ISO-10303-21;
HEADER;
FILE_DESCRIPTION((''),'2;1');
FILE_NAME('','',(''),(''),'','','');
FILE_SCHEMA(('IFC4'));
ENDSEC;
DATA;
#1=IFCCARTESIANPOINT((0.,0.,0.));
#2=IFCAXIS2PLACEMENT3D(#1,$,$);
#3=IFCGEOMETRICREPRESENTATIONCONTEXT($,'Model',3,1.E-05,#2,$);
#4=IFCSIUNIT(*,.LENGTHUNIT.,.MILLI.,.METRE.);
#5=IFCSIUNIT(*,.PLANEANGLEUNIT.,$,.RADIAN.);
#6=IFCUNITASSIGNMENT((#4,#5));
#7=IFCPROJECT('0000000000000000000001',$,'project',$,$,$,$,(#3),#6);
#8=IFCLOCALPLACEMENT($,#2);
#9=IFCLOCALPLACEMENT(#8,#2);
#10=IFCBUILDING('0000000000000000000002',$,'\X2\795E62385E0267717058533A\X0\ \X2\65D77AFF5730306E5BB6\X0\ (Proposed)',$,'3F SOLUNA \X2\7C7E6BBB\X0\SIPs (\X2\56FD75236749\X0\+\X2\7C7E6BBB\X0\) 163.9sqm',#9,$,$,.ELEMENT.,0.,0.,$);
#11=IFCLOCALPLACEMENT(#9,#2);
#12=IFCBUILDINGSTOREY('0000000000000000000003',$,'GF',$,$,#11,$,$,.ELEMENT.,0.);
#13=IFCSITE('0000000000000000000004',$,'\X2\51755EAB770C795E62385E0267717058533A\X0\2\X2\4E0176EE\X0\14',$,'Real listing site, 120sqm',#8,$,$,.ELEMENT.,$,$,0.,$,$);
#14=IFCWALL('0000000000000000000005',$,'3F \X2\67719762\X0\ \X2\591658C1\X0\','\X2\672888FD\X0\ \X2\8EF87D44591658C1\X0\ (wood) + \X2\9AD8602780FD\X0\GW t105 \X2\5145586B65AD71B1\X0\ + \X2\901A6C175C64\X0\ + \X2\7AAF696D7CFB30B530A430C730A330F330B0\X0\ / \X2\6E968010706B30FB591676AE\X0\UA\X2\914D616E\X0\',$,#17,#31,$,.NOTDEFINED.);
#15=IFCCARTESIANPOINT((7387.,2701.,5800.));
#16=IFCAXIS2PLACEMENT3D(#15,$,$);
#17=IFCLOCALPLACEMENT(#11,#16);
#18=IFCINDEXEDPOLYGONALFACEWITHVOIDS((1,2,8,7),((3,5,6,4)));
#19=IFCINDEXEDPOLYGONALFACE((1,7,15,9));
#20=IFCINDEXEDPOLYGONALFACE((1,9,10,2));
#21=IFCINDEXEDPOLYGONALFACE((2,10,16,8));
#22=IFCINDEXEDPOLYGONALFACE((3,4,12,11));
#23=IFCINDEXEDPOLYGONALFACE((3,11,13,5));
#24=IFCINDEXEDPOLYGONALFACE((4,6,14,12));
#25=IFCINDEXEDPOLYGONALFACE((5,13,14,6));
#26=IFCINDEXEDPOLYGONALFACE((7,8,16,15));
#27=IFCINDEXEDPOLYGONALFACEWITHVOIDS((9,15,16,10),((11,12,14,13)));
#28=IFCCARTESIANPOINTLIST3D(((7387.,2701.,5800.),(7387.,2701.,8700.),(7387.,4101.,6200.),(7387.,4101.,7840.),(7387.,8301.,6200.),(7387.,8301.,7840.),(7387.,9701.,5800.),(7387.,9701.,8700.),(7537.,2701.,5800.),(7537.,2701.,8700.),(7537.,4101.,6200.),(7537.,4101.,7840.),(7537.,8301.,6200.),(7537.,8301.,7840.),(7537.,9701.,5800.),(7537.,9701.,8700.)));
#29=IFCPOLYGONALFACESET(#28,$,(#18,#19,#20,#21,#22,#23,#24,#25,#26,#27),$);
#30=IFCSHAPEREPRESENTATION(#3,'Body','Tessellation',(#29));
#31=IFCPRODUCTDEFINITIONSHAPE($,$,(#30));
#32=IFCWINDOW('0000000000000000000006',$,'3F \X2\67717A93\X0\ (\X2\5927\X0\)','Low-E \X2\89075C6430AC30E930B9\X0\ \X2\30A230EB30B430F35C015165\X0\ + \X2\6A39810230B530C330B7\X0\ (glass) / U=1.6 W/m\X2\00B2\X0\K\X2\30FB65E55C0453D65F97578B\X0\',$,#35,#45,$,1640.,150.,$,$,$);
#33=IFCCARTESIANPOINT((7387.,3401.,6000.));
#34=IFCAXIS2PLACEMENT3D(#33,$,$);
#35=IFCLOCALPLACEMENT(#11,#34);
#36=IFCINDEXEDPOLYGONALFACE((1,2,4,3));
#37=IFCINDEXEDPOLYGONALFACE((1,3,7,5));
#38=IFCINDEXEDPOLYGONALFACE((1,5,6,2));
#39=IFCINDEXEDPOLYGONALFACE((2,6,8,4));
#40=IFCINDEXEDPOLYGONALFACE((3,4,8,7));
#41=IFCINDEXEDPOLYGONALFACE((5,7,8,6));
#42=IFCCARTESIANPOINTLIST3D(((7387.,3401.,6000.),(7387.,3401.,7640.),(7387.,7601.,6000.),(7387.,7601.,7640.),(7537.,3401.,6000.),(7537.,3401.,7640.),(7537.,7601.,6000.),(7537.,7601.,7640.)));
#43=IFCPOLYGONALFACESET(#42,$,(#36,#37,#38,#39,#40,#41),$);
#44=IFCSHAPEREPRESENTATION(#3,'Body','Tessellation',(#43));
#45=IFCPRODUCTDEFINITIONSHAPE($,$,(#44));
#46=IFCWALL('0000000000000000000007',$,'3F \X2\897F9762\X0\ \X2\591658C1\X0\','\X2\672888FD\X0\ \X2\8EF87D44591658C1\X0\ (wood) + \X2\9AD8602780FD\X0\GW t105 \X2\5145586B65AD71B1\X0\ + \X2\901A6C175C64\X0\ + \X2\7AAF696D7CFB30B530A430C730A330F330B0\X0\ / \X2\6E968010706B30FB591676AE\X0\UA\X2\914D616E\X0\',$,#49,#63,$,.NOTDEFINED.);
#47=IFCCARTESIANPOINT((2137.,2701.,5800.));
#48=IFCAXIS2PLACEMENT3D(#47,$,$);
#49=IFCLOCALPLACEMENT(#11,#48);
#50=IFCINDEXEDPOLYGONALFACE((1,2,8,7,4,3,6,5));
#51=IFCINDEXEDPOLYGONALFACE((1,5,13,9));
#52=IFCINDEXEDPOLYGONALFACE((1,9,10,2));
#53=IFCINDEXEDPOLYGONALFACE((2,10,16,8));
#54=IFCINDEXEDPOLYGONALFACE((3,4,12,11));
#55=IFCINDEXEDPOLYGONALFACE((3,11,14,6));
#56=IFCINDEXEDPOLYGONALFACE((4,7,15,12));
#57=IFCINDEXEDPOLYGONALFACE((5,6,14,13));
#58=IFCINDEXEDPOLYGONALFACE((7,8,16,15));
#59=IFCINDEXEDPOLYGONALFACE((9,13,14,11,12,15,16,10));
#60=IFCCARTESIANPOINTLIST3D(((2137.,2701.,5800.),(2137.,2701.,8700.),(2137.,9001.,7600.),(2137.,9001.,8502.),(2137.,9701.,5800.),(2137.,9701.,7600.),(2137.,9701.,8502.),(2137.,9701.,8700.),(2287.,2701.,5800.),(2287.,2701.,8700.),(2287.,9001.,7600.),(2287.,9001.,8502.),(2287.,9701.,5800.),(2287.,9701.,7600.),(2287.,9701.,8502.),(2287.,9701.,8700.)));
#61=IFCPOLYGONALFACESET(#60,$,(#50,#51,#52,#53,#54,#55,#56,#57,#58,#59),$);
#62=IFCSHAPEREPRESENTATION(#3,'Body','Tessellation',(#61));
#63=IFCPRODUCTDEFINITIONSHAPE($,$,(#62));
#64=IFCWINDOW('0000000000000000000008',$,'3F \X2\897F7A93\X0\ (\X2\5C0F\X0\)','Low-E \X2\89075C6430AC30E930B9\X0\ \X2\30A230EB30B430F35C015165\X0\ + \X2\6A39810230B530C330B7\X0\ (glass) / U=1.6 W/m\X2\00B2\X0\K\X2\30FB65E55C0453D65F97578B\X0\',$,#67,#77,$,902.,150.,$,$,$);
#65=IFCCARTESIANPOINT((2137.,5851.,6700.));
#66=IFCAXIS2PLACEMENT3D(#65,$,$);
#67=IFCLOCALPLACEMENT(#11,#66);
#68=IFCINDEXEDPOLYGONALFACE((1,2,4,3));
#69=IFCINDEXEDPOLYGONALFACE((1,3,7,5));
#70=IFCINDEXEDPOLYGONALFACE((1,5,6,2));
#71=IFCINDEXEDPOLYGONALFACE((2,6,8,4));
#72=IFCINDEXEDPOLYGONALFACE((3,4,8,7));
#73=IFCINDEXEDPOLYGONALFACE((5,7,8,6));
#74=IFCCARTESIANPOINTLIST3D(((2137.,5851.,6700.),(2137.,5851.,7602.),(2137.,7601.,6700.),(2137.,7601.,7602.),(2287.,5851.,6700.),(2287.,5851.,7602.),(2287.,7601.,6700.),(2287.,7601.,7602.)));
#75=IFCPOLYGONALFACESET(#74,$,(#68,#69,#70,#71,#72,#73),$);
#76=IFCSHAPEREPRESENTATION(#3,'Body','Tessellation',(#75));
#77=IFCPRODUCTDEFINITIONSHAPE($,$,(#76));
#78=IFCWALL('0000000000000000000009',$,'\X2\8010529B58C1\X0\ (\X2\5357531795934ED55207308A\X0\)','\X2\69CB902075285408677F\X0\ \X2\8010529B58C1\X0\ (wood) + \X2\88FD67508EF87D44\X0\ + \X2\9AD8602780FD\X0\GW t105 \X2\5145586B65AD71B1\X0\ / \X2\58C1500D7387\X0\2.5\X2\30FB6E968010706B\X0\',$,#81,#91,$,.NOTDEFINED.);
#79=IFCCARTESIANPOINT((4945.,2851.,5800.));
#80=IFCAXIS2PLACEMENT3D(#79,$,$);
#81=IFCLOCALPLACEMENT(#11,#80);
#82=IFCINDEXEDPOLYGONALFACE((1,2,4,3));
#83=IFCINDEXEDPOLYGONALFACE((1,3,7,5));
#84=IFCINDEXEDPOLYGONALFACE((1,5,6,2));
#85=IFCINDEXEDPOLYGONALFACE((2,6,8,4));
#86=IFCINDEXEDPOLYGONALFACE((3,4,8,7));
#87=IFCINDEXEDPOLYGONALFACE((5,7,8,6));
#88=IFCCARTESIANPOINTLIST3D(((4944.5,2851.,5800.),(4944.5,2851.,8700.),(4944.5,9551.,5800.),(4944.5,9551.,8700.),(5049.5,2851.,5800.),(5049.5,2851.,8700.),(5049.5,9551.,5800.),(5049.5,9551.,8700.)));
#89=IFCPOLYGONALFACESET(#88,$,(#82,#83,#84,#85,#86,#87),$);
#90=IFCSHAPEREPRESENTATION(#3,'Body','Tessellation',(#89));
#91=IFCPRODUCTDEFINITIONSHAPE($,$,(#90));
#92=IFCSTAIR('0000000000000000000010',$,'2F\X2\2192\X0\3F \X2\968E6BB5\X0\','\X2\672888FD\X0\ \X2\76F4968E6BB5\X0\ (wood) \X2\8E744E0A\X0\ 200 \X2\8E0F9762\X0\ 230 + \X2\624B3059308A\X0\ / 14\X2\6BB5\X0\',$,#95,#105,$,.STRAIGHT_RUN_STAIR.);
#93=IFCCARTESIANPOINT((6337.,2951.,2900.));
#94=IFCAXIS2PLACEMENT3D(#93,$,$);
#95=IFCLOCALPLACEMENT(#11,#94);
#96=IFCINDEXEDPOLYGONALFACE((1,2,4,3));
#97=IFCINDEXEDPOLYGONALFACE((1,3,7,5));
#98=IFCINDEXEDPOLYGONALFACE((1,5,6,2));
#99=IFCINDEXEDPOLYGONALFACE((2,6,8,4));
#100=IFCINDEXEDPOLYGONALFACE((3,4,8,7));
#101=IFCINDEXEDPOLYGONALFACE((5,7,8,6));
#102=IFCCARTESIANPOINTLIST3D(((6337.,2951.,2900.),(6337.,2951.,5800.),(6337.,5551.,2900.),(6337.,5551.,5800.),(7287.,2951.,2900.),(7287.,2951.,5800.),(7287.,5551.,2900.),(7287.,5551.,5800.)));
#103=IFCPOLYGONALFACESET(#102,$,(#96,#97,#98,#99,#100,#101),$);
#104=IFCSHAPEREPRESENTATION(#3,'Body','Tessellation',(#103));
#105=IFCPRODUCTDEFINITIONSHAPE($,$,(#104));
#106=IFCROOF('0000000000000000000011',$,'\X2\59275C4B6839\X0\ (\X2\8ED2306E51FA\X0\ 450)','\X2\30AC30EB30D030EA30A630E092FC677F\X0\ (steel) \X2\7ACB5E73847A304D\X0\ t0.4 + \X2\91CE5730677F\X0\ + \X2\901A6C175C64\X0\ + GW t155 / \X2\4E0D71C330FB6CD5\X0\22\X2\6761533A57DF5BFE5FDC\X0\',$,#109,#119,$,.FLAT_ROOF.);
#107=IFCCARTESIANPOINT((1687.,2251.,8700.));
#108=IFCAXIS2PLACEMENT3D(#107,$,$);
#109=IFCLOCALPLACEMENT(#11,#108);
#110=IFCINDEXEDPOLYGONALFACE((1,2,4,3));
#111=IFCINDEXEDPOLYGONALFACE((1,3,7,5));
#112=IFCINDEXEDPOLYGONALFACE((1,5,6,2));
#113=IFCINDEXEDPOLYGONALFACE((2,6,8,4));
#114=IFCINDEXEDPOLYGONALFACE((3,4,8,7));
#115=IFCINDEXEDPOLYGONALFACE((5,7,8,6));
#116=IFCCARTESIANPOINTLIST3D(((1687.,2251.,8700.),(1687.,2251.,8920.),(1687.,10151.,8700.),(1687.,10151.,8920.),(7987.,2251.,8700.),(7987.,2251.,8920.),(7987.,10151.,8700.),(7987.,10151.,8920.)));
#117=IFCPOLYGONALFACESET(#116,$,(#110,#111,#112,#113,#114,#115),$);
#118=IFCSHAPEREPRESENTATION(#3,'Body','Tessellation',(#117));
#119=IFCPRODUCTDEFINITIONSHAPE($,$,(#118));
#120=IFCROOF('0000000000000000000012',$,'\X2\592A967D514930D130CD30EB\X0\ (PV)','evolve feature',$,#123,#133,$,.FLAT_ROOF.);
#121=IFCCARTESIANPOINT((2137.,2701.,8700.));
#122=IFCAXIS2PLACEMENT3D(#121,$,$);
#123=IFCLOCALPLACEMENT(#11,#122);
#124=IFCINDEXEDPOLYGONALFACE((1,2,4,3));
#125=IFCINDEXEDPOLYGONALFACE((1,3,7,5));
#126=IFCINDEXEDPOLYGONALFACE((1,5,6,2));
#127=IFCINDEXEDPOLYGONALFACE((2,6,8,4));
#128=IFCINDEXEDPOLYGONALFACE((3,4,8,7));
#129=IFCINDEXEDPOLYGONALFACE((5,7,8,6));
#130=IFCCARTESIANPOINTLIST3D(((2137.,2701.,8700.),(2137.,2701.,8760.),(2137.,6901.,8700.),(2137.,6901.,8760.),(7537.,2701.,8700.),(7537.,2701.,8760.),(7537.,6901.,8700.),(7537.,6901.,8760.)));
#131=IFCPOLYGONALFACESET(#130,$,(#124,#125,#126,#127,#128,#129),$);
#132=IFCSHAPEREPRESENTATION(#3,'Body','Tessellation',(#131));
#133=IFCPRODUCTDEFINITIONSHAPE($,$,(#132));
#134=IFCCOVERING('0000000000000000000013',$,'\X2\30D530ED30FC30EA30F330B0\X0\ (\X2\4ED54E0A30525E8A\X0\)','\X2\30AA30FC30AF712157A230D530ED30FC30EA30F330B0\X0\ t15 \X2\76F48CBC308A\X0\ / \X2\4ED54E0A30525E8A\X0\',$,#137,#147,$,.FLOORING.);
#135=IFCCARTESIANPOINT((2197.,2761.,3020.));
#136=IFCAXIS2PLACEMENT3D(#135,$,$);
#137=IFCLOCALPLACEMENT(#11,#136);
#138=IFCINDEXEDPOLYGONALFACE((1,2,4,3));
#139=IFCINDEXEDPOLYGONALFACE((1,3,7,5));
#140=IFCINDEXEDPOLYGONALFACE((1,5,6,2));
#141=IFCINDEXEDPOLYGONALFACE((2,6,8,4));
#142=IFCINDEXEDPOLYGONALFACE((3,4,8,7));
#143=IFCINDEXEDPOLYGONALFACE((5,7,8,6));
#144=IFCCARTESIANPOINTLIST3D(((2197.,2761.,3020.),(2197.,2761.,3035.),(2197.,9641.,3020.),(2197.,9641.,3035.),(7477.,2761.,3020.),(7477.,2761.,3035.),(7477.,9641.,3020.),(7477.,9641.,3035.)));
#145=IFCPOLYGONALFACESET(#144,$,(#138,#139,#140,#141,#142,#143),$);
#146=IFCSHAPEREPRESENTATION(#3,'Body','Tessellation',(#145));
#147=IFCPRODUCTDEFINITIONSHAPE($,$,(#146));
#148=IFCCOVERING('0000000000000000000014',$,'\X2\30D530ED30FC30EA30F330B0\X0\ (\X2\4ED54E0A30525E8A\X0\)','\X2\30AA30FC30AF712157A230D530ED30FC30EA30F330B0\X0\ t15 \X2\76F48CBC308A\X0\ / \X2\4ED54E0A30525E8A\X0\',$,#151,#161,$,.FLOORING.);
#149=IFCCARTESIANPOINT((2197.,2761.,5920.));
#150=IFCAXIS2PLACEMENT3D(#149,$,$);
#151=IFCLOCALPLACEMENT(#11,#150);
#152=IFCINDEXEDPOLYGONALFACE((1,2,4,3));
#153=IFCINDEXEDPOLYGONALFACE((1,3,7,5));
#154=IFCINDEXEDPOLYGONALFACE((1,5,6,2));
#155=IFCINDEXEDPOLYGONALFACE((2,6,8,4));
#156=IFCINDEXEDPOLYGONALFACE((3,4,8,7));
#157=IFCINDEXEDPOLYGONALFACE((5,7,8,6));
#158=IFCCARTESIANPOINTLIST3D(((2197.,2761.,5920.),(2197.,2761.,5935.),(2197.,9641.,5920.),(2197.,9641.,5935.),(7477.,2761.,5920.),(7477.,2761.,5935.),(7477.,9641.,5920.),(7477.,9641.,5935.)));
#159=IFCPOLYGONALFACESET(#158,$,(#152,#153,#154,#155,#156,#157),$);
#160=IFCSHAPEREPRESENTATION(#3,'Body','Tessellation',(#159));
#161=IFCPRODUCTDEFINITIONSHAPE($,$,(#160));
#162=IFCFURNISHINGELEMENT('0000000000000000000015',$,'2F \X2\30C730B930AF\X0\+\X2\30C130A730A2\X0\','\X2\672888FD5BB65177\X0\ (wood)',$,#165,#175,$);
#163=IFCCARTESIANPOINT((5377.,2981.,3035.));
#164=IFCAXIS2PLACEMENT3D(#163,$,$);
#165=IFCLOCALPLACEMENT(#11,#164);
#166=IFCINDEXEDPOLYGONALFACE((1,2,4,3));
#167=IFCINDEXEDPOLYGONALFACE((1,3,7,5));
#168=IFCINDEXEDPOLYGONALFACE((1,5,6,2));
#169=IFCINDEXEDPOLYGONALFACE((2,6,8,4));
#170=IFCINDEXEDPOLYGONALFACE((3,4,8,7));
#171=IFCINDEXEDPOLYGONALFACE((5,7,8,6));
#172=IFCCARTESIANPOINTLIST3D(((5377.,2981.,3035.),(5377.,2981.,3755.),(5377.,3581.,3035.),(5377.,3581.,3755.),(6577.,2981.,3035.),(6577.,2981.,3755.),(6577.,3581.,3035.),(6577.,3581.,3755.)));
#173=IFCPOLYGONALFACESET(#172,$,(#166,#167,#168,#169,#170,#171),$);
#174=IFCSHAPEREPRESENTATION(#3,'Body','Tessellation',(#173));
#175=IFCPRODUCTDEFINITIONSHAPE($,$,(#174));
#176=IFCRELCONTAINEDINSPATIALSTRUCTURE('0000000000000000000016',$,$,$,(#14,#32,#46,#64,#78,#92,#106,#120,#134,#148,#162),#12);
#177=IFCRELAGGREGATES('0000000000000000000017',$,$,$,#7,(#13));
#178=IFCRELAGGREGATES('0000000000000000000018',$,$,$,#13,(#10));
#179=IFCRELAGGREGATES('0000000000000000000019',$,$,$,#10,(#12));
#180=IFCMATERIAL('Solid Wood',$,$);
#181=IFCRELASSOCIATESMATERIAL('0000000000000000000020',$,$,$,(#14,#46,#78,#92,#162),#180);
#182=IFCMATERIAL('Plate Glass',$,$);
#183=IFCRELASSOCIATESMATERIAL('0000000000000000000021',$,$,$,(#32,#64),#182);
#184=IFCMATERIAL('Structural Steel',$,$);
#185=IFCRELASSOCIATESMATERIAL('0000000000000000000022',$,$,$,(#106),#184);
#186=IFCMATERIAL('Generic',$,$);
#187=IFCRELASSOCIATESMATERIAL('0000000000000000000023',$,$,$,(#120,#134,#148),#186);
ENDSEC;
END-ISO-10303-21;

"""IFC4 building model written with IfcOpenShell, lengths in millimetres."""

from ifc_helpers import new_model, si_unit, frame, frame_2d, origin, place, context, project, spatial, rectangle, extrude, material, element, fill, save


model = new_model("IFC4")

# Units and contexts
model_context = context("Model", 3, precision=1e-05, world=origin())
ifc_project = project(units=[si_unit("LENGTHUNIT", "METRE", prefix="MILLI"), si_unit("PLANEANGLEUNIT", "RADIAN")], contexts=[model_context])

# Site, building, storey
site_placement = place(None, origin())
site = spatial("IfcSite", under=ifc_project, at=site_placement, Name="兵庫県神戸市東灘区2丁目14", ObjectType="Real listing site, 120sqm", CompositionType="ELEMENT", RefElevation=0.0)
building_placement = place(site_placement, origin())
building = spatial("IfcBuilding", under=site, at=building_placement, Name="神戸市東灘区 旗竿地の家 (Proposed)", ObjectType="3F SOLUNA 籾殻SIPs (国産杉+籾殻) 163.9sqm", CompositionType="ELEMENT", ElevationOfRefHeight=0.0, ElevationOfTerrain=0.0)
storey_placement = place(building_placement, origin())
storey = spatial("IfcBuildingStorey", under=building, at=storey_placement, Name="GF", CompositionType="ELEMENT", Elevation=0.0)

# Shared definitions
ifc_material_1 = material(Name="Solid Wood")

# Shared definitions
ifc_material_2 = material(Name="Plate Glass")

# Shared definitions
ifc_material_3 = material(Name="Generic")

# Walls, openings, windows
wall_1_placement = place(storey_placement, frame((7387.0, 2701.0, 5800.0)))
wall_1 = element("IfcWall", 1, at=wall_1_placement, inside=storey, material=ifc_material_1, Name="3F 東面 外壁", Description="木製 軸組外壁 (wood) + 高性能GW t105 充填断熱 + 通気層 + 窯業系サイディング / 準耐火・外皮UA配慮", PredefinedType="NOTDEFINED", context=model_context, shape_type="SweptSolid", body=[
    extrude(rectangle(XDim=150.0, YDim=7000.0, at=frame_2d((75.0, 3500.0))), frame((7387.0, 2701.0, 5800.0)), (0.0, 0.0, 1.0), 2900.0),
])
opening_1_placement = place(storey_placement, frame((7387.0, 3401.0, 6000.0)))
opening_1 = element("IfcOpeningElement", 2, at=opening_1_placement, cuts=wall_1, PredefinedType="NOTDEFINED", context=model_context, shape_type="SweptSolid", body=[
    extrude(rectangle(XDim=150.0, YDim=4200.0, at=frame_2d((75.0, 2100.0))), frame((7387.0, 3401.0, 6000.0)), (0.0, 0.0, 1.0), 1640.0),
])
window_1_placement = place(storey_placement, frame((7387.0, 3401.0, 6000.0)))
window_1 = element("IfcWindow", 3, at=window_1_placement, inside=storey, material=ifc_material_2, Name="3F 東窓 (大)", Description="Low-E 複層ガラス アルゴン封入 + 樹脂サッシ (glass) / U=1.6 W/m²K・日射取得型", OverallHeight=1640.0, OverallWidth=150.0, context=model_context, shape_type="SweptSolid", body=[
    extrude(rectangle(XDim=150.0, YDim=4200.0, at=frame_2d((75.0, 2100.0))), frame((7387.0, 3401.0, 6000.0)), (0.0, 0.0, 1.0), 1640.0),
])
fill(opening_1, window_1)
wall_2_placement = place(storey_placement, frame((2137.0, 2701.0, 5800.0)))
wall_2 = element("IfcWall", 4, at=wall_2_placement, inside=storey, material=ifc_material_1, Name="3F 西面 外壁", Description="木製 軸組外壁 (wood) + 高性能GW t105 充填断熱 + 通気層 + 窯業系サイディング / 準耐火・外皮UA配慮", PredefinedType="NOTDEFINED", context=model_context, shape_type="SweptSolid", body=[
    extrude(rectangle(XDim=150.0, YDim=7000.0, at=frame_2d((75.0, 3500.0))), frame((2137.0, 2701.0, 5800.0)), (0.0, 0.0, 1.0), 2900.0),
])
opening_2_placement = place(storey_placement, frame((2137.0, 5851.0, 6700.0)))
opening_2 = element("IfcOpeningElement", 5, at=opening_2_placement, cuts=wall_2, PredefinedType="NOTDEFINED", context=model_context, shape_type="SweptSolid", body=[
    extrude(rectangle(XDim=150.0, YDim=1750.0, at=frame_2d((75.0, 875.0))), frame((2137.0, 5851.0, 6700.0)), (0.0, 0.0, 1.0), 902.0),
])
window_2_placement = place(storey_placement, frame((2137.0, 5851.0, 6700.0)))
window_2 = element("IfcWindow", 6, at=window_2_placement, inside=storey, material=ifc_material_2, Name="3F 西窓 (小)", Description="Low-E 複層ガラス アルゴン封入 + 樹脂サッシ (glass) / U=1.6 W/m²K・日射取得型", OverallHeight=902.0, OverallWidth=150.0, context=model_context, shape_type="SweptSolid", body=[
    extrude(rectangle(XDim=150.0, YDim=1750.0, at=frame_2d((75.0, 875.0))), frame((2137.0, 5851.0, 6700.0)), (0.0, 0.0, 1.0), 902.0),
])
fill(opening_2, window_2)

# Wall
wall_3_placement = place(storey_placement, frame((4945.0, 2851.0, 5800.0)))
element("IfcWall", 7, at=wall_3_placement, inside=storey, material=ifc_material_1, Name="耐力壁 (南北間仕切り)", Description="構造用合板 耐力壁 (wood) + 製材軸組 + 高性能GW t105 充填断熱 / 壁倍率2.5・準耐火", PredefinedType="NOTDEFINED", context=model_context, shape_type="SweptSolid", body=[
    extrude(rectangle(XDim=105.0, YDim=6700.0, at=frame_2d((52.0, 3350.0))), frame((4945.0, 2851.0, 5800.0)), (0.0, 0.0, 1.0), 2900.0),
])

# Stair
stair_placement = place(storey_placement, frame((6337.0, 2951.0, 2900.0)))
element("IfcStair", 8, at=stair_placement, inside=storey, material=ifc_material_1, Name="2F→3F 階段", Description="木製 直階段 (wood) 蹴上 200 踏面 230 + 手すり / 14段", PredefinedType="STRAIGHT_RUN_STAIR", context=model_context, shape_type="SweptSolid", body=[
    extrude(rectangle(XDim=950.0, YDim=2600.0, at=frame_2d((475.0, 1300.0))), frame((6337.0, 2951.0, 2900.0)), (0.0, 0.0, 1.0), 2900.0),
])

# Roofs
ifc_material_4 = material(Name="Structural Steel")
roof_1_placement = place(storey_placement, frame((1687.0, 2251.0, 8700.0)))
element("IfcRoof", 9, at=roof_1_placement, inside=storey, material=ifc_material_4, Name="大屋根 (軒の出 450)", Description="ガルバリウム鋼板 (steel) 立平葺き t0.4 + 野地板 + 通気層 + GW t155 / 不燃・法22条区域対応", PredefinedType="FLAT_ROOF", context=model_context, shape_type="SweptSolid", body=[
    extrude(rectangle(XDim=6300.0, YDim=7900.0, at=frame_2d((3150.0, 3950.0))), frame((1687.0, 2251.0, 8700.0)), (0.0, 0.0, 1.0), 220.0),
])
roof_2_placement = place(storey_placement, frame((2137.0, 2701.0, 8700.0)))
element("IfcRoof", 10, at=roof_2_placement, inside=storey, material=ifc_material_3, Name="太陽光パネル (PV)", Description="evolve feature", PredefinedType="FLAT_ROOF", context=model_context, shape_type="SweptSolid", body=[
    extrude(rectangle(XDim=5400.0, YDim=4200.0, at=frame_2d((2700.0, 2100.0))), frame((2137.0, 2701.0, 8700.0)), (0.0, 0.0, 1.0), 60.0),
])

# Coverings
covering_1_placement = place(storey_placement, frame((2197.0, 2761.0, 3020.0)))
element("IfcCovering", 11, at=covering_1_placement, inside=storey, material=ifc_material_3, Name="フローリング (仕上げ床)", Description="オーク無垢フローリング t15 直貼り / 仕上げ床", PredefinedType="FLOORING", context=model_context, shape_type="SweptSolid", body=[
    extrude(rectangle(XDim=5280.0, YDim=6880.0, at=frame_2d((2640.0, 3440.0))), frame((2197.0, 2761.0, 3020.0)), (0.0, 0.0, 1.0), 15.0),
])
covering_2_placement = place(storey_placement, frame((2197.0, 2761.0, 5920.0)))
element("IfcCovering", 12, at=covering_2_placement, inside=storey, material=ifc_material_3, Name="フローリング (仕上げ床)", Description="オーク無垢フローリング t15 直貼り / 仕上げ床", PredefinedType="FLOORING", context=model_context, shape_type="SweptSolid", body=[
    extrude(rectangle(XDim=5280.0, YDim=6880.0, at=frame_2d((2640.0, 3440.0))), frame((2197.0, 2761.0, 5920.0)), (0.0, 0.0, 1.0), 15.0),
])

# Furnishing element
furnishing_placement = place(storey_placement, frame((5377.0, 2981.0, 3035.0)))
element("IfcFurnishingElement", 13, at=furnishing_placement, inside=storey, material=ifc_material_1, Name="2F デスク+チェア", Description="木製家具 (wood)", context=model_context, shape_type="SweptSolid", body=[
    extrude(rectangle(XDim=1200.0, YDim=600.0, at=frame_2d((600.0, 300.0))), frame((5377.0, 2981.0, 3035.0)), (0.0, 0.0, 1.0), 720.0),
])

save(model, "model.ifc")
